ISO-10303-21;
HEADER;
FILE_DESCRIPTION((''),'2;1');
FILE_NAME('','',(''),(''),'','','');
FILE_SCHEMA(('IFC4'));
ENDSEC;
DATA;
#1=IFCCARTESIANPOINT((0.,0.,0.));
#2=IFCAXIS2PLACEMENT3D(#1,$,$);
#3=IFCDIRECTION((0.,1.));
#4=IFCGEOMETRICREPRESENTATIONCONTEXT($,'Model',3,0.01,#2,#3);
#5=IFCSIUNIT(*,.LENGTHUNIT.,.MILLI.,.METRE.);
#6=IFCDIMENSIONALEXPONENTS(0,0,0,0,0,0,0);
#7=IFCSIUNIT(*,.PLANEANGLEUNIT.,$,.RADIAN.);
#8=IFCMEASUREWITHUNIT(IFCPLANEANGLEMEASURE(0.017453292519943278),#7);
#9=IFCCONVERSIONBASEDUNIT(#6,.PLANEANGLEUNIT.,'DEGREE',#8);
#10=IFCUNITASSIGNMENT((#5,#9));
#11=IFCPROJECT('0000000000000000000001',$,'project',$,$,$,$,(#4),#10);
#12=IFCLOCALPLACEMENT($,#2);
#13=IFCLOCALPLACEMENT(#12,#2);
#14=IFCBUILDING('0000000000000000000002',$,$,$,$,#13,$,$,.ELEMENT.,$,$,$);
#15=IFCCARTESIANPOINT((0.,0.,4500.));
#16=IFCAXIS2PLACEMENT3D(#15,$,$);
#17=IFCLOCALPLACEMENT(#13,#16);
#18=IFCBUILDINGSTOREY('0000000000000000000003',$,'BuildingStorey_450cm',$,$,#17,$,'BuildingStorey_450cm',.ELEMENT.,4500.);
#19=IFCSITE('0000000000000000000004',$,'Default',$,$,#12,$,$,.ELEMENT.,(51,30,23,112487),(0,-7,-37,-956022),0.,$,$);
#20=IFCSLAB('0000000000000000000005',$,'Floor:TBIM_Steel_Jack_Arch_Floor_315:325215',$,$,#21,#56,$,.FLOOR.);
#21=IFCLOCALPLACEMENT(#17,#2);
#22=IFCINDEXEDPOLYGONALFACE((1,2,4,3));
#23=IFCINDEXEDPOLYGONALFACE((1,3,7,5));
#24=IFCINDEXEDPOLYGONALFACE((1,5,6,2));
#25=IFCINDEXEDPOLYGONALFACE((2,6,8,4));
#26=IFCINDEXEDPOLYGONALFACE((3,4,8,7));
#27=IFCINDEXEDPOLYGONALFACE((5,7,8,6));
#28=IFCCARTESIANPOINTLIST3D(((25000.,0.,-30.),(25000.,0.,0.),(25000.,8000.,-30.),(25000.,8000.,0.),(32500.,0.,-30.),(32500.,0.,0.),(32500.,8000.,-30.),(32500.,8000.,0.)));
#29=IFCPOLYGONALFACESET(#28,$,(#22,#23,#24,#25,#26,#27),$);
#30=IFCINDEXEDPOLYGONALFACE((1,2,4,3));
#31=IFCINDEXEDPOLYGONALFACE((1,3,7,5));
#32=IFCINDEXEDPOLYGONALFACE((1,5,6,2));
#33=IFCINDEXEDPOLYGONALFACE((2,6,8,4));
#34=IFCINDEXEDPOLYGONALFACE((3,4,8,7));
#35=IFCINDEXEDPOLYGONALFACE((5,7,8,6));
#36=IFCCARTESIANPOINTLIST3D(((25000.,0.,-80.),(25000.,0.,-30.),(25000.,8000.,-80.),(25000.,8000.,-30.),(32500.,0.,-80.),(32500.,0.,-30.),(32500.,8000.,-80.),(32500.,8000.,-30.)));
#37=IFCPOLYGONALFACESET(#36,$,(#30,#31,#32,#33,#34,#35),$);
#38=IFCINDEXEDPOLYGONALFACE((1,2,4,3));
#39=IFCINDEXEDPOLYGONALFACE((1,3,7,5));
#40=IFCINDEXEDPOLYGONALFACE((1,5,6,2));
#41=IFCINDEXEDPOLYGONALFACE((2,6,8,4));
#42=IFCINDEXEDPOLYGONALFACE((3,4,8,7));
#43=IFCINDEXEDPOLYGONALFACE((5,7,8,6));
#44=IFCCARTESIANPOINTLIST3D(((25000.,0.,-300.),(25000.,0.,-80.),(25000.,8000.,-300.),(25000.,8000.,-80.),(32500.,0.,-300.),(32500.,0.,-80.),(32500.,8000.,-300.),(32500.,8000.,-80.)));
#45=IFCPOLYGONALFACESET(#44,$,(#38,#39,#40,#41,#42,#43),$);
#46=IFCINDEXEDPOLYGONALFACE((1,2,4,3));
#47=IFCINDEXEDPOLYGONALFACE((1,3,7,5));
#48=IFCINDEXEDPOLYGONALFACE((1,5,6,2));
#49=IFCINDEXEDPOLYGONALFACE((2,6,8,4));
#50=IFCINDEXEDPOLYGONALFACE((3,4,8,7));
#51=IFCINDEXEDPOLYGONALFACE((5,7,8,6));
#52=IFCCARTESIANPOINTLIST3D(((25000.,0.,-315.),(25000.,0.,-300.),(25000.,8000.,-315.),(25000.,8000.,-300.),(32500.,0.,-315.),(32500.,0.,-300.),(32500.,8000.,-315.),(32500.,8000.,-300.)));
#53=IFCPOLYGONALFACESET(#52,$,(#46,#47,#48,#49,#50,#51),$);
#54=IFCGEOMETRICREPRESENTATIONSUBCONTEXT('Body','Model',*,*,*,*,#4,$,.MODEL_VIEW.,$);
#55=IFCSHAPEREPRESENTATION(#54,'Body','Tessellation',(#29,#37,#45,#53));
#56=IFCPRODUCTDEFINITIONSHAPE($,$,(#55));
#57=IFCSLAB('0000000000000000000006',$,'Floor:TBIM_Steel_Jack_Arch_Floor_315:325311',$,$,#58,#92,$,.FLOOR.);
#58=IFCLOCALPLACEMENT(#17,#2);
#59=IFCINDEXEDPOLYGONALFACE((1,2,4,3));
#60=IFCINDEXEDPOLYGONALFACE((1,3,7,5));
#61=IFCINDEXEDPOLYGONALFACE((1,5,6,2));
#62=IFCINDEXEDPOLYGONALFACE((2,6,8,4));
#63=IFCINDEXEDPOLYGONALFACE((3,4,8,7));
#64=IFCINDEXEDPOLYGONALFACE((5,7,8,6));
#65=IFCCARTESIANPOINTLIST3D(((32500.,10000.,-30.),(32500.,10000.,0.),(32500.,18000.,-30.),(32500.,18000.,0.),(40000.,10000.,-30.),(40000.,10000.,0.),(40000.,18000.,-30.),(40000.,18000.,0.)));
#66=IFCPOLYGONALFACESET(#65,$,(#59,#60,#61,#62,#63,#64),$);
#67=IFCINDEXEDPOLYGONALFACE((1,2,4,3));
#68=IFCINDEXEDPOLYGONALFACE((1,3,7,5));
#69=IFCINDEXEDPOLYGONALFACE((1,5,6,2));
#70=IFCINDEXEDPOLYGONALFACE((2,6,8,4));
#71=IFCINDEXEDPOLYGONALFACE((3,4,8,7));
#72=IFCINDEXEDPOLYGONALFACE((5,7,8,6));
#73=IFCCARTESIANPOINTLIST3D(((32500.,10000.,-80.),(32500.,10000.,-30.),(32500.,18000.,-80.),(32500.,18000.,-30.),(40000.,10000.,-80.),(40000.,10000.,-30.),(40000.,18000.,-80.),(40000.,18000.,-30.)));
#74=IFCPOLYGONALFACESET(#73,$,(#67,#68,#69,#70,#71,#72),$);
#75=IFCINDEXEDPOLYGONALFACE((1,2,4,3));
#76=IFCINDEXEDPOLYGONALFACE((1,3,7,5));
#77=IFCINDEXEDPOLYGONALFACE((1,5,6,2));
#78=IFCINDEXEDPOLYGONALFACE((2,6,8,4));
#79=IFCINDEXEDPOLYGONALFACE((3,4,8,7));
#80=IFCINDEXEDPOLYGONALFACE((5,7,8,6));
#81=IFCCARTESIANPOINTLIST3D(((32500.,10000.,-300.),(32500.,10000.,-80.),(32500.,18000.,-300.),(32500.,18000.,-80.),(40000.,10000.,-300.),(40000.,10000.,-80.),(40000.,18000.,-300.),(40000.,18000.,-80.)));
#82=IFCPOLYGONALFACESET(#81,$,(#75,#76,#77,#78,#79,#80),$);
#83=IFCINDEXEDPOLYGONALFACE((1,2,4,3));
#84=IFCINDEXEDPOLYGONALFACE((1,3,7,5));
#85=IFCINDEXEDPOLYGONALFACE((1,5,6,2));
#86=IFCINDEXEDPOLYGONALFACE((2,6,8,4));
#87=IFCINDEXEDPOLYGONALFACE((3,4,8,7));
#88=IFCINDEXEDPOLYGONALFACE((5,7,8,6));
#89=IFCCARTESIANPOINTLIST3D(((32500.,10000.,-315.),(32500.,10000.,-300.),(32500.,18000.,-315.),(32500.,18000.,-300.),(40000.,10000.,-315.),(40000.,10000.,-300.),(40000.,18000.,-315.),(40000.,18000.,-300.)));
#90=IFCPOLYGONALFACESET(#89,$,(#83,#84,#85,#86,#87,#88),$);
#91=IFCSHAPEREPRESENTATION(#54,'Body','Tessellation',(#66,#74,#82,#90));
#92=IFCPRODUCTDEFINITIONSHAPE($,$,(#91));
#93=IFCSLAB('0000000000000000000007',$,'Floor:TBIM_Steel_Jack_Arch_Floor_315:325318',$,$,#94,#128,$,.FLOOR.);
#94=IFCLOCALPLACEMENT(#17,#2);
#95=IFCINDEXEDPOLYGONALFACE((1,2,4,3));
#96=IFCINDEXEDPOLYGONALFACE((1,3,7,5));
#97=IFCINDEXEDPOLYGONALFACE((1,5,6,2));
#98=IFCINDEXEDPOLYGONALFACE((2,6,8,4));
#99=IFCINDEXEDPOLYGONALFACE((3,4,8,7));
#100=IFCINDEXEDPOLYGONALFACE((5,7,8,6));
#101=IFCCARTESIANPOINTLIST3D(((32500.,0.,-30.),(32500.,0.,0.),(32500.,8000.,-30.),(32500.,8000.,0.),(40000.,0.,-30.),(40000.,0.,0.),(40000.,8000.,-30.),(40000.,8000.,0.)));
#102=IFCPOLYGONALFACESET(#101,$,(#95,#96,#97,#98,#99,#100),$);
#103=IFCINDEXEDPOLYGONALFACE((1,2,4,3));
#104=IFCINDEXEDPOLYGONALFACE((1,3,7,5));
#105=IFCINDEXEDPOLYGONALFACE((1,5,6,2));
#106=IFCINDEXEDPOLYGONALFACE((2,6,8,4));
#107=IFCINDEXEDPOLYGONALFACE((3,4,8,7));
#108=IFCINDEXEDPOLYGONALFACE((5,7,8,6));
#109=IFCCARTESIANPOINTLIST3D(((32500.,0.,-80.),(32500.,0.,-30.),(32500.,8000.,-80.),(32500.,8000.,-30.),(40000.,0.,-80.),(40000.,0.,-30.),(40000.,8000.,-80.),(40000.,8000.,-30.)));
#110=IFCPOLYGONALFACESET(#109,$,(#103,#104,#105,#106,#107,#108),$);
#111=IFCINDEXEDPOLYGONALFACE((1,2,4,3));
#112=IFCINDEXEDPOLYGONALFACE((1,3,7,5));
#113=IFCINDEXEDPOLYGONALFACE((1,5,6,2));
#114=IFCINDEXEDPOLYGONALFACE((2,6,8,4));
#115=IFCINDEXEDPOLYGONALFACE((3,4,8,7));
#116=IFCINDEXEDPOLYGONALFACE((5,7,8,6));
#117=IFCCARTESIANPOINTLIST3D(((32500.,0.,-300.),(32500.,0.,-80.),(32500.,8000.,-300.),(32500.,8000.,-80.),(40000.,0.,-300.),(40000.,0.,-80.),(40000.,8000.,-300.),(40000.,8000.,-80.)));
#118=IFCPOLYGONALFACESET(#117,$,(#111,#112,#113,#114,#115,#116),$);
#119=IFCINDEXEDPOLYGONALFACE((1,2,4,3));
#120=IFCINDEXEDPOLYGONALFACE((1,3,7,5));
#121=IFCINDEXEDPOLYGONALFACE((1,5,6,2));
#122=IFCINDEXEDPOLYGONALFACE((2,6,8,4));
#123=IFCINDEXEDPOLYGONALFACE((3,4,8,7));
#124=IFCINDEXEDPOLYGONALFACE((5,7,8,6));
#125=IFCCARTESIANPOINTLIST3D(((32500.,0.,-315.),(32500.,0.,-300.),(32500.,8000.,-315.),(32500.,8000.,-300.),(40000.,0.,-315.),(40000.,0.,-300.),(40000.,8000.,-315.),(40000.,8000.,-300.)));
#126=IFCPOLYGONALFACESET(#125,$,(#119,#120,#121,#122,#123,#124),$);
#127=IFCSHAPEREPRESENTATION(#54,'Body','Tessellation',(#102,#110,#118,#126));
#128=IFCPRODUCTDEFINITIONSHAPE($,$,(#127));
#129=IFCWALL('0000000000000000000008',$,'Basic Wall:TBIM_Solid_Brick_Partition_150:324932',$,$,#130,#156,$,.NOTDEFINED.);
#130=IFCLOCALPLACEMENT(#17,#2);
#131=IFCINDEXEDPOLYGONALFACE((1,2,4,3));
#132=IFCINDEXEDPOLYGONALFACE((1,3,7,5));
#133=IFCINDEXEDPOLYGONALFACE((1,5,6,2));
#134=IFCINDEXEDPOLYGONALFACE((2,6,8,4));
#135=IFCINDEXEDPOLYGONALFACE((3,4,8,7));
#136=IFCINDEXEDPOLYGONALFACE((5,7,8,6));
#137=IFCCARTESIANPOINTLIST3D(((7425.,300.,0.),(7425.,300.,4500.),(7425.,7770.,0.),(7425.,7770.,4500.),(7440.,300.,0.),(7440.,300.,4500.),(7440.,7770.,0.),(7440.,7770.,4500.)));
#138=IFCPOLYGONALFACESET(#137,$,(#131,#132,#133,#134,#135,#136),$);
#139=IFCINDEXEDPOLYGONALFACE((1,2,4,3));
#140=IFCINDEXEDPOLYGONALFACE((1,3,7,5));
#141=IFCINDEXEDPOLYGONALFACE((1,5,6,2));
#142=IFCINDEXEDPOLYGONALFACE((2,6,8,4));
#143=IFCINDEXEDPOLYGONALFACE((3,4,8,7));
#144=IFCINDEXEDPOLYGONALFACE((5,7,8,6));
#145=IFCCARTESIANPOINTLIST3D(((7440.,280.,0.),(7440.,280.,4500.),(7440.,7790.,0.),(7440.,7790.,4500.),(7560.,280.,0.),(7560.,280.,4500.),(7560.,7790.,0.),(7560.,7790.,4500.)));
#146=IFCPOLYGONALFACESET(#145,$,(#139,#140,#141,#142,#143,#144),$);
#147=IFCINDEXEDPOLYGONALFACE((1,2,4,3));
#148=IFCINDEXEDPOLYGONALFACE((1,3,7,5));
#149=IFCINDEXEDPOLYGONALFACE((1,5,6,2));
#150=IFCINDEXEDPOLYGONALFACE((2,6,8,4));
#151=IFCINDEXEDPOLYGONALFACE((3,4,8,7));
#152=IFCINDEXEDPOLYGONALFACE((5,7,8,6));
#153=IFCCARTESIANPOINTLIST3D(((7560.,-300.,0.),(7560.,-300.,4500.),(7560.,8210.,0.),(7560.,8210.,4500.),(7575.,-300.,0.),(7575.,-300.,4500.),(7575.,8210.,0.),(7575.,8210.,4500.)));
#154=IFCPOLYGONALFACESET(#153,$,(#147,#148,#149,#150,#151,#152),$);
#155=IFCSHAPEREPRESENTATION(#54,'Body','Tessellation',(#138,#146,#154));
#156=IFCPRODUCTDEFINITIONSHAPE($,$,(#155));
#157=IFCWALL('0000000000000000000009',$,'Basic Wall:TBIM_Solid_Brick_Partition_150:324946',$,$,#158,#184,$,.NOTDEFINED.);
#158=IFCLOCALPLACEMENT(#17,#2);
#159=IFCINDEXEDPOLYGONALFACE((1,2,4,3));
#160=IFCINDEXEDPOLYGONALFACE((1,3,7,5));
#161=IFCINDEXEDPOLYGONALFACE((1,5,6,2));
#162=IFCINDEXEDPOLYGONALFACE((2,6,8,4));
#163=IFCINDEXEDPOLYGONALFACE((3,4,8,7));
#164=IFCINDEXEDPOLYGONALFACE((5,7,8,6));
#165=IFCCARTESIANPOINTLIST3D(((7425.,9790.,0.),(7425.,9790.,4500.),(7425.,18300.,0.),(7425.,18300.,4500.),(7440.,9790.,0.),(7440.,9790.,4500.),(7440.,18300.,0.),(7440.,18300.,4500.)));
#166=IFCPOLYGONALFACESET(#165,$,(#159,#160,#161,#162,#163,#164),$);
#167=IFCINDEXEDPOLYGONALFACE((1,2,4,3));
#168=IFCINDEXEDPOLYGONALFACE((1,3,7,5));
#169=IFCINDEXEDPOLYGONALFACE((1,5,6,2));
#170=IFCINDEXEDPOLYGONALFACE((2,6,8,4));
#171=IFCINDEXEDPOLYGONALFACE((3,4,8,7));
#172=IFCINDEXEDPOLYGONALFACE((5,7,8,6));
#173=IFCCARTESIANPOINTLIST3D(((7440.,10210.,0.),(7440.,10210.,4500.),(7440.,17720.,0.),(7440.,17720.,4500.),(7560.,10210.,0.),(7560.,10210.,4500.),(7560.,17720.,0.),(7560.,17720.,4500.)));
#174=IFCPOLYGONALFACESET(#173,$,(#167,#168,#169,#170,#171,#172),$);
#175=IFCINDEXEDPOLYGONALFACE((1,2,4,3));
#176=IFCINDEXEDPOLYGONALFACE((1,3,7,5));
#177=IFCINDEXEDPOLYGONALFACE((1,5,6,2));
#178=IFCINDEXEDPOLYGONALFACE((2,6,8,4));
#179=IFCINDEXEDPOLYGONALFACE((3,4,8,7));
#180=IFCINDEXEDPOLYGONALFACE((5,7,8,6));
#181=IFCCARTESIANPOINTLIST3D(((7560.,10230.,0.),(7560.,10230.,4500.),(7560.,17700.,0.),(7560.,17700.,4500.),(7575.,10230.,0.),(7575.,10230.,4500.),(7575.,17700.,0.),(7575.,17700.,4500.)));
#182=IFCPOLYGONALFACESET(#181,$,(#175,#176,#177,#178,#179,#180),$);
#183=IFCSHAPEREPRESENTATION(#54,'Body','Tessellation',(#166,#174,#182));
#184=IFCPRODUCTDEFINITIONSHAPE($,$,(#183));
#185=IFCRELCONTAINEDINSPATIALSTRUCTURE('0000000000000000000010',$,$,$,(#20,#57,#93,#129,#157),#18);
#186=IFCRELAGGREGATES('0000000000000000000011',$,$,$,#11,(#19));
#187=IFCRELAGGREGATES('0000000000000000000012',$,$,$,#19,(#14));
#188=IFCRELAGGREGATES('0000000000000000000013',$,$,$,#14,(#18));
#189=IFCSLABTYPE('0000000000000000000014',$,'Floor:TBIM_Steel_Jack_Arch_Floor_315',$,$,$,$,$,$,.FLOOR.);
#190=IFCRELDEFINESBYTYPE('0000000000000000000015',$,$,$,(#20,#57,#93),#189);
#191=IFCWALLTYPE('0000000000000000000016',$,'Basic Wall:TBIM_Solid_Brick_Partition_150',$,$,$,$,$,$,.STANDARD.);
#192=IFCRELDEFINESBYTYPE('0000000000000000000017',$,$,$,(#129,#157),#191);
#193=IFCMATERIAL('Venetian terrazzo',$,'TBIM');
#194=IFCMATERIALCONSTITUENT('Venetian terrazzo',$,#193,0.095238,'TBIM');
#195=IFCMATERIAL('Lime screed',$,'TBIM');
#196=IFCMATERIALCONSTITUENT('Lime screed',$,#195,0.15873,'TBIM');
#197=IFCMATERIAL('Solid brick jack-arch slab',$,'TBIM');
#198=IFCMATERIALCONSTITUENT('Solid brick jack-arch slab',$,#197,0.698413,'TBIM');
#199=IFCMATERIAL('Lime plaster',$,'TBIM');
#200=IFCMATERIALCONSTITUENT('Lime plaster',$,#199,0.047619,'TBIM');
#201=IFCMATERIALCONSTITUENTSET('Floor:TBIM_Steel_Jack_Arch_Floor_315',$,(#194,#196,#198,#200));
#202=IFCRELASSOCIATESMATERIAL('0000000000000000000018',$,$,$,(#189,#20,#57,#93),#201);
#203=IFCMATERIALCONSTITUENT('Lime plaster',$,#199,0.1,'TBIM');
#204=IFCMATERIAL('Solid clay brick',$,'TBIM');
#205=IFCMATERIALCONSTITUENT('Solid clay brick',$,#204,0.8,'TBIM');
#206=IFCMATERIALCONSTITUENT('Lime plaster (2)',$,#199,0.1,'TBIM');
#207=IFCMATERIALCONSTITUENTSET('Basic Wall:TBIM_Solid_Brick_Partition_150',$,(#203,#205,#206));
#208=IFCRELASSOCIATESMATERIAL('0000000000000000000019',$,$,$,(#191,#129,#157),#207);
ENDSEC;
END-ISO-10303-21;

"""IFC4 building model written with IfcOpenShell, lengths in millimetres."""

from ifc_helpers import new_model, entity, si_unit, converted_unit, direction, frame, origin, place, context, subcontext, project, spatial, indexed_curve, outline, extrude, material, constituent, constituent_set, type_object, element, save


model = new_model("IFC4")

# Units and contexts
model_context = context("Model", 3, precision=0.01, world=origin(), true_north=direction((0.0, 1.0)))
body_context = subcontext(model_context, "Body", "Model", "MODEL_VIEW")
ifc_project = project(units=[si_unit("LENGTHUNIT", "METRE", prefix="MILLI"), converted_unit("PLANEANGLEUNIT", "DEGREE", entity("IfcPlaneAngleMeasure", 0.017453292519943278), si_unit("PLANEANGLEUNIT", "RADIAN"), dimensions=[0, 0, 0, 0, 0, 0, 0])], contexts=[model_context])

# Site, building, storey
site_placement = place(None, origin())
site = spatial("IfcSite", under=ifc_project, at=site_placement, Name="Default", CompositionType="ELEMENT", RefLatitude=(51, 30, 23, 112487), RefLongitude=(0, -7, -37, -956022), RefElevation=0.0)
building_placement = place(site_placement, origin())
building = spatial("IfcBuilding", under=site, at=building_placement, CompositionType="ELEMENT")
storey_placement = place(building_placement, frame((0.0, 0.0, 4500.0)))
storey = spatial("IfcBuildingStorey", under=building, at=storey_placement, Name="BuildingStorey_450cm", LongName="BuildingStorey_450cm", CompositionType="ELEMENT", Elevation=4500.0)

# Slabs
ifc_material_1 = material(Name="Venetian terrazzo", Category="TBIM")
ifc_constituent_1 = constituent(ifc_material_1, Name="Venetian terrazzo", Category="TBIM", fraction=0.095238)
ifc_material_2 = material(Name="Lime screed", Category="TBIM")
ifc_constituent_2 = constituent(ifc_material_2, Name="Lime screed", Category="TBIM", fraction=0.15873)
ifc_material_3 = material(Name="Solid brick jack-arch slab", Category="TBIM")
ifc_constituent_3 = constituent(ifc_material_3, Name="Solid brick jack-arch slab", Category="TBIM", fraction=0.698413)
ifc_material_4 = material(Name="Lime plaster", Category="TBIM")
ifc_constituent_4 = constituent(ifc_material_4, Name="Lime plaster", Category="TBIM", fraction=0.047619)
ifc_constituent_set_1 = constituent_set(constituents=[ifc_constituent_1, ifc_constituent_2, ifc_constituent_3, ifc_constituent_4], Name="Floor:TBIM_Steel_Jack_Arch_Floor_315")
slab_type = type_object("IfcSlabType", Name="Floor:TBIM_Steel_Jack_Arch_Floor_315", PredefinedType="FLOOR", material=ifc_constituent_set_1)
slab_1_placement = place(storey_placement, origin())
element("IfcSlab", 1, at=slab_1_placement, inside=storey, type_object=slab_type, material=ifc_constituent_set_1, Name="Floor:TBIM_Steel_Jack_Arch_Floor_315:325215", PredefinedType="FLOOR", context=body_context, shape_type="SweptSolid", body=[
    extrude(outline(indexed_curve([(-3750.0, -4000.0), (3750.0, -4000.0), (3750.0, 4000.0), (-3750.0, 4000.0), (-3750.0, -4000.0)], self_intersect=False)), frame((28750.0, 4000.0, -30.0), z_axis=(0.0, 0.0, 1.0), x_axis=(-1.0, 0.0, 0.0)), (0.0, 0.0, 1.0), 30.0),
    extrude(outline(indexed_curve([(-3750.0, -4000.0), (3750.0, -4000.0), (3750.0, 4000.0), (-3750.0, 4000.0), (-3750.0, -4000.0)], self_intersect=False)), frame((28750.0, 4000.0, -80.0), z_axis=(0.0, 0.0, 1.0), x_axis=(-1.0, 0.0, 0.0)), (0.0, 0.0, 1.0), 50.0),
    extrude(outline(indexed_curve([(-3750.0, -4000.0), (3750.0, -4000.0), (3750.0, 4000.0), (-3750.0, 4000.0), (-3750.0, -4000.0)], self_intersect=False)), frame((28750.0, 4000.0, -300.0), z_axis=(0.0, 0.0, 1.0), x_axis=(-1.0, 0.0, 0.0)), (0.0, 0.0, 1.0), 220.0),
    extrude(outline(indexed_curve([(-3750.0, -4000.0), (3750.0, -4000.0), (3750.0, 4000.0), (-3750.0, 4000.0), (-3750.0, -4000.0)], self_intersect=False)), frame((28750.0, 4000.0, -315.0), z_axis=(0.0, 0.0, 1.0), x_axis=(-1.0, 0.0, 0.0)), (0.0, 0.0, 1.0), 15.0),
])
slab_2_placement = place(storey_placement, origin())
element("IfcSlab", 2, at=slab_2_placement, inside=storey, type_object=slab_type, material=ifc_constituent_set_1, Name="Floor:TBIM_Steel_Jack_Arch_Floor_315:325311", PredefinedType="FLOOR", context=body_context, shape_type="SweptSolid", body=[
    extrude(outline(indexed_curve([(-3750.0, -4000.0), (3750.0, -4000.0), (3750.0, 4000.0), (-3750.0, 4000.0), (-3750.0, -4000.0)], self_intersect=False)), frame((36250.0, 14000.0, -30.0), z_axis=(0.0, 0.0, 1.0), x_axis=(-1.0, 0.0, 0.0)), (0.0, 0.0, 1.0), 30.0),
    extrude(outline(indexed_curve([(-3750.0, -4000.0), (3750.0, -4000.0), (3750.0, 4000.0), (-3750.0, 4000.0), (-3750.0, -4000.0)], self_intersect=False)), frame((36250.0, 14000.0, -80.0), z_axis=(0.0, 0.0, 1.0), x_axis=(-1.0, 0.0, 0.0)), (0.0, 0.0, 1.0), 50.0),
    extrude(outline(indexed_curve([(-3750.0, -4000.0), (3750.0, -4000.0), (3750.0, 4000.0), (-3750.0, 4000.0), (-3750.0, -4000.0)], self_intersect=False)), frame((36250.0, 14000.0, -300.0), z_axis=(0.0, 0.0, 1.0), x_axis=(-1.0, 0.0, 0.0)), (0.0, 0.0, 1.0), 220.0),
    extrude(outline(indexed_curve([(-3750.0, -4000.0), (3750.0, -4000.0), (3750.0, 4000.0), (-3750.0, 4000.0), (-3750.0, -4000.0)], self_intersect=False)), frame((36250.0, 14000.0, -315.0), z_axis=(0.0, 0.0, 1.0), x_axis=(-1.0, 0.0, 0.0)), (0.0, 0.0, 1.0), 15.0),
])
slab_3_placement = place(storey_placement, origin())
element("IfcSlab", 3, at=slab_3_placement, inside=storey, type_object=slab_type, material=ifc_constituent_set_1, Name="Floor:TBIM_Steel_Jack_Arch_Floor_315:325318", PredefinedType="FLOOR", context=body_context, shape_type="SweptSolid", body=[
    extrude(outline(indexed_curve([(-3750.0, -4000.0), (3750.0, -4000.0), (3750.0, 4000.0), (-3750.0, 4000.0), (-3750.0, -4000.0)], self_intersect=False)), frame((36250.0, 4000.0, -30.0), z_axis=(0.0, 0.0, 1.0), x_axis=(-1.0, 0.0, 0.0)), (0.0, 0.0, 1.0), 30.0),
    extrude(outline(indexed_curve([(-3750.0, -4000.0), (3750.0, -4000.0), (3750.0, 4000.0), (-3750.0, 4000.0), (-3750.0, -4000.0)], self_intersect=False)), frame((36250.0, 4000.0, -80.0), z_axis=(0.0, 0.0, 1.0), x_axis=(-1.0, 0.0, 0.0)), (0.0, 0.0, 1.0), 50.0),
    extrude(outline(indexed_curve([(-3750.0, -4000.0), (3750.0, -4000.0), (3750.0, 4000.0), (-3750.0, 4000.0), (-3750.0, -4000.0)], self_intersect=False)), frame((36250.0, 4000.0, -300.0), z_axis=(0.0, 0.0, 1.0), x_axis=(-1.0, 0.0, 0.0)), (0.0, 0.0, 1.0), 220.0),
    extrude(outline(indexed_curve([(-3750.0, -4000.0), (3750.0, -4000.0), (3750.0, 4000.0), (-3750.0, 4000.0), (-3750.0, -4000.0)], self_intersect=False)), frame((36250.0, 4000.0, -315.0), z_axis=(0.0, 0.0, 1.0), x_axis=(-1.0, 0.0, 0.0)), (0.0, 0.0, 1.0), 15.0),
])

# Shared definitions
ifc_material_5 = material(Name="Solid clay brick", Category="TBIM")

# Walls
ifc_constituent_5 = constituent(ifc_material_4, Name="Lime plaster", Category="TBIM", fraction=0.1)
ifc_constituent_6 = constituent(ifc_material_5, Name="Solid clay brick", Category="TBIM", fraction=0.8)
ifc_constituent_7 = constituent(ifc_material_4, Name="Lime plaster (2)", Category="TBIM", fraction=0.1)
ifc_constituent_set_2 = constituent_set(constituents=[ifc_constituent_5, ifc_constituent_6, ifc_constituent_7], Name="Basic Wall:TBIM_Solid_Brick_Partition_150")
wall_type_1 = type_object("IfcWallType", Name="Basic Wall:TBIM_Solid_Brick_Partition_150", PredefinedType="STANDARD", material=ifc_constituent_set_2)
wall_1_placement = place(storey_placement, frame((7500.0, 300.0, 0.0), z_axis=(0.0, 0.0, 1.0), x_axis=(0.0, 1.0, 0.0)))
element("IfcWall", 4, at=wall_1_placement, inside=storey, type_object=wall_type_1, material=ifc_constituent_set_2, Name="Basic Wall:TBIM_Solid_Brick_Partition_150:324932", PredefinedType="NOTDEFINED", context=body_context, shape_type="SweptSolid", body=[
    extrude(outline(indexed_curve([(-7.5, -3735.0), (7.5, -3735.0), (7.5, 3735.0), (-7.5, 3735.0), (-7.5, -3735.0)], self_intersect=False)), frame((3735.0, 67.5, 0.0), z_axis=(0.0, 0.0, 1.0), x_axis=(0.0, -1.0, 0.0)), (0.0, 0.0, 1.0), 4500.0),
    extrude(outline(indexed_curve([(-3755.0, -60.0), (3755.0, -60.0), (3755.0, 60.0), (-3755.0, 60.0), (-3755.0, -60.0)], self_intersect=False)), frame((3735.0, 0.0, 0.0)), (0.0, 0.0, 1.0), 4500.0),
    extrude(outline(indexed_curve([(-7.5, -4255.0), (7.5, -4255.0), (7.5, 4255.0), (-7.5, 4255.0), (-7.5, -4255.0)], self_intersect=False)), frame((3655.0, -67.5, 0.0), z_axis=(0.0, 0.0, 1.0), x_axis=(0.0, 1.0, 0.0)), (0.0, 0.0, 1.0), 4500.0),
])
wall_2_placement = place(storey_placement, frame((7500.0, 10230.0, 0.0), z_axis=(0.0, 0.0, 1.0), x_axis=(0.0, 1.0, 0.0)))
element("IfcWall", 5, at=wall_2_placement, inside=storey, type_object=wall_type_1, material=ifc_constituent_set_2, Name="Basic Wall:TBIM_Solid_Brick_Partition_150:324946", PredefinedType="NOTDEFINED", context=body_context, shape_type="SweptSolid", body=[
    extrude(outline(indexed_curve([(-7.5, -4255.0), (7.5, -4255.0), (7.5, 4255.0), (-7.5, 4255.0), (-7.5, -4255.0)], self_intersect=False)), frame((3815.0, 67.5, 0.0), z_axis=(0.0, 0.0, 1.0), x_axis=(0.0, -1.0, 0.0)), (0.0, 0.0, 1.0), 4500.0),
    extrude(outline(indexed_curve([(-3755.0, -60.0), (3755.0, -60.0), (3755.0, 60.0), (-3755.0, 60.0), (-3755.0, -60.0)], self_intersect=False)), frame((3735.0, 0.0, 0.0)), (0.0, 0.0, 1.0), 4500.0),
    extrude(outline(indexed_curve([(-7.5, -3735.0), (7.5, -3735.0), (7.5, 3735.0), (-7.5, 3735.0), (-7.5, -3735.0)], self_intersect=False)), frame((3735.0, -67.5, 0.0), z_axis=(0.0, 0.0, 1.0), x_axis=(0.0, 1.0, 0.0)), (0.0, 0.0, 1.0), 4500.0),
])

save(model, "model.ifc")
